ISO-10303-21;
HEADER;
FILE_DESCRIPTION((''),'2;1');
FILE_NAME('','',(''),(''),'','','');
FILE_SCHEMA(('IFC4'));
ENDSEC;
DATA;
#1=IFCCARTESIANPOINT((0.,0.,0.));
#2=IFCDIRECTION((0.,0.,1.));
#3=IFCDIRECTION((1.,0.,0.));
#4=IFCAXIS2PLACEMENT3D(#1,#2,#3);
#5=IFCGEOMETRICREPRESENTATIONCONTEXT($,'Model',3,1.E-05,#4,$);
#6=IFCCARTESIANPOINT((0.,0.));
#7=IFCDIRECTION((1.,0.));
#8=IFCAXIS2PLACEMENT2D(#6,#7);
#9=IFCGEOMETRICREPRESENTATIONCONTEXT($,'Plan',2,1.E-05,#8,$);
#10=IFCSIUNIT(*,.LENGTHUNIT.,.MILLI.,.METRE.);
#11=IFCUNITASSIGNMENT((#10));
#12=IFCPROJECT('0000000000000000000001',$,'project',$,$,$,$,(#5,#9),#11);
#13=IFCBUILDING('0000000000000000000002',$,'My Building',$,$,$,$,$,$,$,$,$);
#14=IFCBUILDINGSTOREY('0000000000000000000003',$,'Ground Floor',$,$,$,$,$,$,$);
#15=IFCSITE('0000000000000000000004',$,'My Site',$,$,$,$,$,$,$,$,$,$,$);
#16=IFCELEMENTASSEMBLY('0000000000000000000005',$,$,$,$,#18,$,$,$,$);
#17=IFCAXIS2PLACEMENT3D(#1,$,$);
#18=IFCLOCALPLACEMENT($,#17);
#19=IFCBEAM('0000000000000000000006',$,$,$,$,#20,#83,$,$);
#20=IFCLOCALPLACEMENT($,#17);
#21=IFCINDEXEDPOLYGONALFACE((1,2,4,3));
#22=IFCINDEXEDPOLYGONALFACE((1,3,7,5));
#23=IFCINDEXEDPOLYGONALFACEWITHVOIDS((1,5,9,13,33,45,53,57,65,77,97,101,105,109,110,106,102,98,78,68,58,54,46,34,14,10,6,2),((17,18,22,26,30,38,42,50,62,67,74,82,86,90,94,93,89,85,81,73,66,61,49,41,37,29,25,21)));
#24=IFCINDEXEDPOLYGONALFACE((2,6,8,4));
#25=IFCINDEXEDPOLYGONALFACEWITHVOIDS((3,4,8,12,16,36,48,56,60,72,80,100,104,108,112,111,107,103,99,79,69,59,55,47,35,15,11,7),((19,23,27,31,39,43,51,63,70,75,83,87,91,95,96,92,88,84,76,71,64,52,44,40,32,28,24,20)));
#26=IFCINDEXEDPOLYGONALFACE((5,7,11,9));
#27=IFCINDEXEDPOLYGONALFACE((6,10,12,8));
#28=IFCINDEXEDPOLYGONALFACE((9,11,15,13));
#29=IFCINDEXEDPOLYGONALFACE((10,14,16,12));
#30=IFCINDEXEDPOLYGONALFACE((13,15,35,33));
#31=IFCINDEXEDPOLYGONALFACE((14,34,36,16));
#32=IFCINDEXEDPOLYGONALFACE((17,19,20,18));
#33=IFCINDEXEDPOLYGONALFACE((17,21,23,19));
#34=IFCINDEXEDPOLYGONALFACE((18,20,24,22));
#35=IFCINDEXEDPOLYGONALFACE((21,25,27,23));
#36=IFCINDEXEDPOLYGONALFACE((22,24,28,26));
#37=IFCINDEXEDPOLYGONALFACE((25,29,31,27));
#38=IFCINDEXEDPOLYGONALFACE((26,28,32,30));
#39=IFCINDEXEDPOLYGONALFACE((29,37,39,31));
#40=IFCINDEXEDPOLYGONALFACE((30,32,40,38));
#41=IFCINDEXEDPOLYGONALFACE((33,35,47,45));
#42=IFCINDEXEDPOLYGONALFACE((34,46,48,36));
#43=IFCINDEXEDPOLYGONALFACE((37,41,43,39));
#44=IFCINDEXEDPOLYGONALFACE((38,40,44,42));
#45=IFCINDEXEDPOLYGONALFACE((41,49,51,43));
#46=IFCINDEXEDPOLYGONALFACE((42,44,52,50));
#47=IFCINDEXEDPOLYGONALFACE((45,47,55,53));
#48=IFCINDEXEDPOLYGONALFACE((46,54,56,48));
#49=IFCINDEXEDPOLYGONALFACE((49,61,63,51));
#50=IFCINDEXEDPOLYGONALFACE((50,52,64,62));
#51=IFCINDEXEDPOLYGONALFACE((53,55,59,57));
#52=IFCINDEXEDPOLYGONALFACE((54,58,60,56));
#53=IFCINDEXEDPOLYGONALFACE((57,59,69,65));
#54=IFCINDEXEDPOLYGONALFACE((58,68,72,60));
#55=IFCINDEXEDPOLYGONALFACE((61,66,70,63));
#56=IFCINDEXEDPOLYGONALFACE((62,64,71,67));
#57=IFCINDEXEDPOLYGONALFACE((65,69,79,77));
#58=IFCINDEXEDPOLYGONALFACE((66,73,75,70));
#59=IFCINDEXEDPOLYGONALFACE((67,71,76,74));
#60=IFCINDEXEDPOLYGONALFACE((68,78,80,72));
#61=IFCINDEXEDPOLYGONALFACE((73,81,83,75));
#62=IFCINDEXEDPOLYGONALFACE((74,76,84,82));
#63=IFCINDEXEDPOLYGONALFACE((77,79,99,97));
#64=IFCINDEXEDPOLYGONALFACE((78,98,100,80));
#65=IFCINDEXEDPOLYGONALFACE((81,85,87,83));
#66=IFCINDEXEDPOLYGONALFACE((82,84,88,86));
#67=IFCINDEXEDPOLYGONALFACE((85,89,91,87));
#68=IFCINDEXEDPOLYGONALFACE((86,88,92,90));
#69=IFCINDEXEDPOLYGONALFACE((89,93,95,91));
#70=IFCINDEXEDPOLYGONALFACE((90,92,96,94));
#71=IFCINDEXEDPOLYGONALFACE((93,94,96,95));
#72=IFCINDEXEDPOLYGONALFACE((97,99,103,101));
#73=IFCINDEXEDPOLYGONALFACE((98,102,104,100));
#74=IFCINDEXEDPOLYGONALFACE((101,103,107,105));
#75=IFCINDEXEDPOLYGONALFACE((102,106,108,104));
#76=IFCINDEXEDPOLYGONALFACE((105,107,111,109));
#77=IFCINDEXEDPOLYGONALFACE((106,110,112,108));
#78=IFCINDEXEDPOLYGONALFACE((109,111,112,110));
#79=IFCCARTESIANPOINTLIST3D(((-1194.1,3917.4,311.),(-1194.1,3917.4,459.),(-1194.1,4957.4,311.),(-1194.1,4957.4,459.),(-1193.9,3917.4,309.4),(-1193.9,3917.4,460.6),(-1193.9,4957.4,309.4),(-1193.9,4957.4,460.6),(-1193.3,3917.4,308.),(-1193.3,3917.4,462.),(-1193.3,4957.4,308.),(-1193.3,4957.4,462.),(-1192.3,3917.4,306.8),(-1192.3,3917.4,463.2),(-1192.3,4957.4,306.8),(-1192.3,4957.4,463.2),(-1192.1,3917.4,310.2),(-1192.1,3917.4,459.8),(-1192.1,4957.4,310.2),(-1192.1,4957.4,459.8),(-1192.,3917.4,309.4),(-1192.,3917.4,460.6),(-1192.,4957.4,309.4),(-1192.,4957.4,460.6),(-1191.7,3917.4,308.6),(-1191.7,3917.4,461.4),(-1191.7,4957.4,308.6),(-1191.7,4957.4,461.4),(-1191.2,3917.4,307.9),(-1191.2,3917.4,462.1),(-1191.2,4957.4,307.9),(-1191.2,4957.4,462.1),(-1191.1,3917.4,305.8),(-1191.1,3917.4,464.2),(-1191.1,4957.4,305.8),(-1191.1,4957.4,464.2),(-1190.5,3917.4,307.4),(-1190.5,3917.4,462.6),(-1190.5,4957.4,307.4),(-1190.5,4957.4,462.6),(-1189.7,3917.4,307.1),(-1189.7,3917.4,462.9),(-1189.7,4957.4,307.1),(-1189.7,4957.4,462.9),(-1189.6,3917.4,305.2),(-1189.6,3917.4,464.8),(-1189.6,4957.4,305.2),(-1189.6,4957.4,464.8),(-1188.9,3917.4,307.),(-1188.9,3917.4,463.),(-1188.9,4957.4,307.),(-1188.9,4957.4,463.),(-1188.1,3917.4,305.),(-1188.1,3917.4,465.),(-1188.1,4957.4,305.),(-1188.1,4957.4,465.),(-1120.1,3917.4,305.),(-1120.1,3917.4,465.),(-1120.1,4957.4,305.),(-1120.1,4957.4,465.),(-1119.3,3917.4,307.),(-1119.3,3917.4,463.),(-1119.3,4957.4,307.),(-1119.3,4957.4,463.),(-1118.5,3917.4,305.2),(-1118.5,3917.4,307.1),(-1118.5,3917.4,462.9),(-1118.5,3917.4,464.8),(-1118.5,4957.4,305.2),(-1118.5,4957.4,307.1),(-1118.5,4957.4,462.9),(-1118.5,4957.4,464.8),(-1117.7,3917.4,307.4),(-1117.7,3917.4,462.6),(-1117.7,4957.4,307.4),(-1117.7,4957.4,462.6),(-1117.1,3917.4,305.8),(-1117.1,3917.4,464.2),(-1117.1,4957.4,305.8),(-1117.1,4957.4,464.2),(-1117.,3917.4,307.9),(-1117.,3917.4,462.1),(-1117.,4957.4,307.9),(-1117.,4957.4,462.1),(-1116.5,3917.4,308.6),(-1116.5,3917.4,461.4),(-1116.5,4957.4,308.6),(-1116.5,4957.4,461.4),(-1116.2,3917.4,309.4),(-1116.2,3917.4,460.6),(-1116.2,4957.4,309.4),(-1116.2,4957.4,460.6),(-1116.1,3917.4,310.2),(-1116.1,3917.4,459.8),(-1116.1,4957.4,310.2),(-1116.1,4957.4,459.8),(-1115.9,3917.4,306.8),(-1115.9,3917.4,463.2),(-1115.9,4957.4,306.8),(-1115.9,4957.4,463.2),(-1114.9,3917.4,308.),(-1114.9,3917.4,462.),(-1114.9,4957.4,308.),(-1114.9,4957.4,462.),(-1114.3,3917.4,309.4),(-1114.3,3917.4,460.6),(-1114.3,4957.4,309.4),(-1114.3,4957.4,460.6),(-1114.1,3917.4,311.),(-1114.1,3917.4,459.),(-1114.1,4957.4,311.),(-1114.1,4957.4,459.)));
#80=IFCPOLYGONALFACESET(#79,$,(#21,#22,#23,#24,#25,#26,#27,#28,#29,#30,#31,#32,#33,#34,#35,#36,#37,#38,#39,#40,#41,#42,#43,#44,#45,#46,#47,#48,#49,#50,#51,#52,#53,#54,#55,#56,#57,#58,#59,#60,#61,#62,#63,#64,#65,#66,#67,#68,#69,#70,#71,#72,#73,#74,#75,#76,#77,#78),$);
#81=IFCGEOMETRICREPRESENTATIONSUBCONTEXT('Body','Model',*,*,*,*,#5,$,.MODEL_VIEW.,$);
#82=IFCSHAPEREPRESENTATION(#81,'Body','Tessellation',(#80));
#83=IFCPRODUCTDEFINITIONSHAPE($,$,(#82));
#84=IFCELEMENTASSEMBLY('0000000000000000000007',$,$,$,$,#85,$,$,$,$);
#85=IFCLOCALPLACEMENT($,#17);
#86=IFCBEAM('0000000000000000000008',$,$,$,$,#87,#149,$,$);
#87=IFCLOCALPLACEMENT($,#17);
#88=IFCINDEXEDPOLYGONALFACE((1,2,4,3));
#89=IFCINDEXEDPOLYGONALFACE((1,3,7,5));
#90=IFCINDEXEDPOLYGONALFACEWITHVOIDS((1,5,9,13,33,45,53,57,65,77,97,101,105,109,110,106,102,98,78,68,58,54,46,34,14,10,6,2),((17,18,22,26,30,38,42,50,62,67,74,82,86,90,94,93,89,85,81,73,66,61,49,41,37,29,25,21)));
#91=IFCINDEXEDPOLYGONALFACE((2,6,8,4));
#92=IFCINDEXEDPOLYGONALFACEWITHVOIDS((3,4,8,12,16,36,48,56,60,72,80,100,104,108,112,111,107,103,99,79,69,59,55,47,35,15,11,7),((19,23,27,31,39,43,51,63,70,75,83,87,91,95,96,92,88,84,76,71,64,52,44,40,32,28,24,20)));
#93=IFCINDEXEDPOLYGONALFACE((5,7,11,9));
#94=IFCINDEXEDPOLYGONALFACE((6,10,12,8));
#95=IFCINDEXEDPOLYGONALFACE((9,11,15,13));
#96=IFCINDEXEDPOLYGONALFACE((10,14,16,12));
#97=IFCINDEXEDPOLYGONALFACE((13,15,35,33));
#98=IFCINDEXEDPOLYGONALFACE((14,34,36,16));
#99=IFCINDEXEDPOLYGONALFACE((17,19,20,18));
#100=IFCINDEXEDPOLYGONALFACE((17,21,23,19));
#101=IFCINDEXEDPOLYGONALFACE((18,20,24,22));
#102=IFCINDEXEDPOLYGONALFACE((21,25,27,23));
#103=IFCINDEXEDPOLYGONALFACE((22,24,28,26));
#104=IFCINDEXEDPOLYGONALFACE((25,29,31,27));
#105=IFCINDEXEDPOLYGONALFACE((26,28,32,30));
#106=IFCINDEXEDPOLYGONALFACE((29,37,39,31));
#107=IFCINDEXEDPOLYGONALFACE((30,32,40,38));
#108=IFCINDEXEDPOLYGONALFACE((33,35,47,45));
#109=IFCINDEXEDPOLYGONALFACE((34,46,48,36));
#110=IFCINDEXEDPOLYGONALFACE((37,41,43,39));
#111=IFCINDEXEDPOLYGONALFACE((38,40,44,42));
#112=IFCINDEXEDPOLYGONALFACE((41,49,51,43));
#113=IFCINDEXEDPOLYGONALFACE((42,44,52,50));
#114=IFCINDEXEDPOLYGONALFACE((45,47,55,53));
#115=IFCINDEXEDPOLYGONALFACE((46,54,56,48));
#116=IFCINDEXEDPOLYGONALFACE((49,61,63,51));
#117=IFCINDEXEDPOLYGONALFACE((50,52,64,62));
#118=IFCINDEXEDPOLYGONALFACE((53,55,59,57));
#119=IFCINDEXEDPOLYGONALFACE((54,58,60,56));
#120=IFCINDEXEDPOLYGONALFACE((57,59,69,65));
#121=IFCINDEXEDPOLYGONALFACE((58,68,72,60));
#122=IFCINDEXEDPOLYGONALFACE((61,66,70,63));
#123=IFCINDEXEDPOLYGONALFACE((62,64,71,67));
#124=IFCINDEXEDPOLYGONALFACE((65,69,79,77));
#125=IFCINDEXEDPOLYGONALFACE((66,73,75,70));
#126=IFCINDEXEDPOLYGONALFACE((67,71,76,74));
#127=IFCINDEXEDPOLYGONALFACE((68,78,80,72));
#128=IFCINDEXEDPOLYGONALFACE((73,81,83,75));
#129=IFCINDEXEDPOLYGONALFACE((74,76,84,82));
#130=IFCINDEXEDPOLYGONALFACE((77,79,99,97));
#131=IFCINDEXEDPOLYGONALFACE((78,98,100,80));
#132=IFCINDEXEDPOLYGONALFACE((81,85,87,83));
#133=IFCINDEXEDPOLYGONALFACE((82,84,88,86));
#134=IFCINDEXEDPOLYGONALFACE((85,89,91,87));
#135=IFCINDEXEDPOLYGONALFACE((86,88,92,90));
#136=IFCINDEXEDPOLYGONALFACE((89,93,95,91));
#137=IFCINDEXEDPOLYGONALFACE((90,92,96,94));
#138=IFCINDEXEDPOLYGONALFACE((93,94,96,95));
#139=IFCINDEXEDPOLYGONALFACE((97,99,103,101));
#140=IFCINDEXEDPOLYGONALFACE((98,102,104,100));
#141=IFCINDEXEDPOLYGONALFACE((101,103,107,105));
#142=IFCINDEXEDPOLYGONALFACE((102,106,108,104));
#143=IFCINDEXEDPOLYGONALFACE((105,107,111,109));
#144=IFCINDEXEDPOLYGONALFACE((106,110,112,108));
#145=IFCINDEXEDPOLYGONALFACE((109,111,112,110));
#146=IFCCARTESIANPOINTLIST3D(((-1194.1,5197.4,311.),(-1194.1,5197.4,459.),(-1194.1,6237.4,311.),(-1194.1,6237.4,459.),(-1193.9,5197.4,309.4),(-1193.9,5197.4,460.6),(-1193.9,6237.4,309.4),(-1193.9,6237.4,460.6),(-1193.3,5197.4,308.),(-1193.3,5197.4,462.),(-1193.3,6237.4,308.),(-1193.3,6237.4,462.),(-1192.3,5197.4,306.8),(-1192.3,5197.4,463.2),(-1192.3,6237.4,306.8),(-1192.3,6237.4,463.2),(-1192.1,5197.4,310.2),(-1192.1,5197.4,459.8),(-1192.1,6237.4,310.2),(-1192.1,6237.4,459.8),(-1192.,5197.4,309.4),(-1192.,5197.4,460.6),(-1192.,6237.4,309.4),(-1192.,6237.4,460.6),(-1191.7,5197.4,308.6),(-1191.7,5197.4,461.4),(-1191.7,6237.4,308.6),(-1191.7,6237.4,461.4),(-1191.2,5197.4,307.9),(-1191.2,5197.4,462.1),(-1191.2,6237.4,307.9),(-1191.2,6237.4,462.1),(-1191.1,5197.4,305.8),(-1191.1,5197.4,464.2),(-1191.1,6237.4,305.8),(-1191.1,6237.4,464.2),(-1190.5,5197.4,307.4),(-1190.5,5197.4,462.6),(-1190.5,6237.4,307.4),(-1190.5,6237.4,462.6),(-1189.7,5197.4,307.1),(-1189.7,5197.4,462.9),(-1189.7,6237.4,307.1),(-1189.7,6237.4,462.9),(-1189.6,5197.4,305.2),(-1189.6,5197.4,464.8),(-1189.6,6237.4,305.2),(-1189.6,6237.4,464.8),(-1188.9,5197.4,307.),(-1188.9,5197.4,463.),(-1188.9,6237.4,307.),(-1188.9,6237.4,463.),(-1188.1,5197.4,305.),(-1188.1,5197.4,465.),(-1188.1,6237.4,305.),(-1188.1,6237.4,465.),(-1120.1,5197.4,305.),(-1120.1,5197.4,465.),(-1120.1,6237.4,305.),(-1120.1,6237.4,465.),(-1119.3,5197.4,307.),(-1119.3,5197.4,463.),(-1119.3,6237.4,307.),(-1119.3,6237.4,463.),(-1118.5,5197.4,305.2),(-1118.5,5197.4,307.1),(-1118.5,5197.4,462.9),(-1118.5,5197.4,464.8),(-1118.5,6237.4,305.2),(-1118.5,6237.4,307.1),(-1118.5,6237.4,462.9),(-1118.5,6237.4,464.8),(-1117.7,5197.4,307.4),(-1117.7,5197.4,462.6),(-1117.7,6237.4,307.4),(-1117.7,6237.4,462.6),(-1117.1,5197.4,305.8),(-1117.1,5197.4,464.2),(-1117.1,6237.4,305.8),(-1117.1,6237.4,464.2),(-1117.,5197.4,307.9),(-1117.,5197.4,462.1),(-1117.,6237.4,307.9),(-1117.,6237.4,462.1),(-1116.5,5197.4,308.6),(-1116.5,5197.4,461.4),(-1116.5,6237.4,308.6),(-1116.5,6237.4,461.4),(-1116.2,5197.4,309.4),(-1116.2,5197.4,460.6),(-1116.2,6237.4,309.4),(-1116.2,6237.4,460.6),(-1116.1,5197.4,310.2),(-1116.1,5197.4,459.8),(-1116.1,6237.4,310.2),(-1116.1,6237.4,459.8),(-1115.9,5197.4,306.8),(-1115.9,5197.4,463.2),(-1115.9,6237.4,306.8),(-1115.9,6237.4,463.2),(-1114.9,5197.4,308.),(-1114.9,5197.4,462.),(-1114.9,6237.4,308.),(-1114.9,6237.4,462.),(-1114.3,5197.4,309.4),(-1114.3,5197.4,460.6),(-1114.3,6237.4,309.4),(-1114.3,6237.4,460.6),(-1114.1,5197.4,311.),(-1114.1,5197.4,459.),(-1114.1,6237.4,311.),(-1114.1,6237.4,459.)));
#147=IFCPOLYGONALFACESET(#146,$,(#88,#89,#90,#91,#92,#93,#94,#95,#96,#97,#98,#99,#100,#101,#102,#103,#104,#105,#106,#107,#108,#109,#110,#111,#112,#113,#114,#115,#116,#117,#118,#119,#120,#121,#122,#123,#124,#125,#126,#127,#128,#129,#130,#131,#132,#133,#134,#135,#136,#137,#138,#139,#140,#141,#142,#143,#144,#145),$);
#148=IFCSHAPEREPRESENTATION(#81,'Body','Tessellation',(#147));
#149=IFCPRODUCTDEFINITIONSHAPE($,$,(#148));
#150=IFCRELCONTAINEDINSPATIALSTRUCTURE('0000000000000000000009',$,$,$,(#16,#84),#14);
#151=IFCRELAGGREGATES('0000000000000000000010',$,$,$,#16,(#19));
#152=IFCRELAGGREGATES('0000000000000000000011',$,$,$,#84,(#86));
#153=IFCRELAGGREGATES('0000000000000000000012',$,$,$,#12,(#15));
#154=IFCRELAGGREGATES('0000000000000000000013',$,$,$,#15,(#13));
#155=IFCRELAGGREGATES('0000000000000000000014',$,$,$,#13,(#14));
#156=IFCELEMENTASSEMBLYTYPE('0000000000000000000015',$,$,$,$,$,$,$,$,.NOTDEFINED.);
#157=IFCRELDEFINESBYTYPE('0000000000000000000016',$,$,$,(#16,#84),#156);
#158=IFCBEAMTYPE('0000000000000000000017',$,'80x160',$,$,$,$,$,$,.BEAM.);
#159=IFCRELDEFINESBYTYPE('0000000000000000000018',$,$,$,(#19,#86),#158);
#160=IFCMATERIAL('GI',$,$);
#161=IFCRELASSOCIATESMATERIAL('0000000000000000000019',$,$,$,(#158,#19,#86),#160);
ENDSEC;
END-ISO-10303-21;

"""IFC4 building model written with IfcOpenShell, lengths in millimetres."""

from ifc_helpers import new_model, si_unit, frame, origin_with_axes, origin_2d_with_axis, place, context, subcontext, project, spatial, hollow_rectangle, extrude, material, material_profile, profile_set, profile_usage, type_object, element, aggregate, save


model = new_model("IFC4")

# Units and contexts
model_context = context("Model", 3, precision=1e-05, world=origin_with_axes())
plan_context = context("Plan", 2, precision=1e-05, world=origin_2d_with_axis())
body_context = subcontext(model_context, "Body", "Model", "MODEL_VIEW")
ifc_project = project(units=[si_unit("LENGTHUNIT", "METRE", prefix="MILLI")], contexts=[model_context, plan_context])

# Site, building, storey
site = spatial("IfcSite", under=ifc_project, Name="My Site")
building = spatial("IfcBuilding", under=site, Name="My Building")
storey = spatial("IfcBuildingStorey", under=building, Name="Ground Floor")

# Shared definitions
ifc_material = material(Name="GI")

# Element assemblies, beams
element_assembly_type_1 = type_object("IfcElementAssemblyType", PredefinedType="NOTDEFINED")
ifc_material_profile_1 = material_profile(ifc_material, hollow_rectangle(XDim=80.0, YDim=160.0, WallThickness=2.0, InnerFilletRadius=3.2, OuterFilletRadius=6.0))
ifc_profile_set_1 = profile_set([ifc_material_profile_1], Name="80x160 GI Rectangular Hollow")
beam_type = type_object("IfcBeamType", Name="80x160", PredefinedType="BEAM", material=ifc_profile_set_1)
assembly_1_placement = place(None, frame((-1154.1, 3837.4, 385.0), z_axis=(0.0, 1.0, 0.0), x_axis=(1.0, 0.0, 0.0)))
assembly_1 = element("IfcElementAssembly", 1, at=assembly_1_placement, inside=storey, type_object=element_assembly_type_1)
ifc_profile_usage_1 = profile_usage(ifc_profile_set_1)
beam_1_placement = place(assembly_1_placement, frame((0.0, 0.0, 80.0), z_axis=(0.0, 0.0, 1.0), x_axis=(1.0, 0.0, 0.0)))
beam_1 = element("IfcBeam", 2, at=beam_1_placement, type_object=beam_type, material=ifc_profile_usage_1, context=body_context, shape_type="SweptSolid", body=[
    extrude(hollow_rectangle(XDim=80.0, YDim=160.0, WallThickness=2.0, InnerFilletRadius=3.2, OuterFilletRadius=6.0), origin_with_axes(), (0.0, 0.0, 1.0), 1040.0),
])
aggregate(assembly_1, [beam_1])
assembly_2_placement = place(None, frame((-1154.1, 5117.4, 385.0), z_axis=(0.0, 1.0, 0.0), x_axis=(1.0, 0.0, 0.0)))
assembly_2 = element("IfcElementAssembly", 3, at=assembly_2_placement, inside=storey, type_object=element_assembly_type_1)
ifc_profile_usage_2 = profile_usage(ifc_profile_set_1)
beam_2_placement = place(assembly_2_placement, frame((0.0, 0.0, 80.0), z_axis=(0.0, 0.0, 1.0), x_axis=(1.0, 0.0, 0.0)))
beam_2 = element("IfcBeam", 4, at=beam_2_placement, type_object=beam_type, material=ifc_profile_usage_2, context=body_context, shape_type="SweptSolid", body=[
    extrude(hollow_rectangle(XDim=80.0, YDim=160.0, WallThickness=2.0, InnerFilletRadius=3.2, OuterFilletRadius=6.0), origin_with_axes(), (0.0, 0.0, 1.0), 1040.0),
])
aggregate(assembly_2, [beam_2])

save(model, "model.ifc")
